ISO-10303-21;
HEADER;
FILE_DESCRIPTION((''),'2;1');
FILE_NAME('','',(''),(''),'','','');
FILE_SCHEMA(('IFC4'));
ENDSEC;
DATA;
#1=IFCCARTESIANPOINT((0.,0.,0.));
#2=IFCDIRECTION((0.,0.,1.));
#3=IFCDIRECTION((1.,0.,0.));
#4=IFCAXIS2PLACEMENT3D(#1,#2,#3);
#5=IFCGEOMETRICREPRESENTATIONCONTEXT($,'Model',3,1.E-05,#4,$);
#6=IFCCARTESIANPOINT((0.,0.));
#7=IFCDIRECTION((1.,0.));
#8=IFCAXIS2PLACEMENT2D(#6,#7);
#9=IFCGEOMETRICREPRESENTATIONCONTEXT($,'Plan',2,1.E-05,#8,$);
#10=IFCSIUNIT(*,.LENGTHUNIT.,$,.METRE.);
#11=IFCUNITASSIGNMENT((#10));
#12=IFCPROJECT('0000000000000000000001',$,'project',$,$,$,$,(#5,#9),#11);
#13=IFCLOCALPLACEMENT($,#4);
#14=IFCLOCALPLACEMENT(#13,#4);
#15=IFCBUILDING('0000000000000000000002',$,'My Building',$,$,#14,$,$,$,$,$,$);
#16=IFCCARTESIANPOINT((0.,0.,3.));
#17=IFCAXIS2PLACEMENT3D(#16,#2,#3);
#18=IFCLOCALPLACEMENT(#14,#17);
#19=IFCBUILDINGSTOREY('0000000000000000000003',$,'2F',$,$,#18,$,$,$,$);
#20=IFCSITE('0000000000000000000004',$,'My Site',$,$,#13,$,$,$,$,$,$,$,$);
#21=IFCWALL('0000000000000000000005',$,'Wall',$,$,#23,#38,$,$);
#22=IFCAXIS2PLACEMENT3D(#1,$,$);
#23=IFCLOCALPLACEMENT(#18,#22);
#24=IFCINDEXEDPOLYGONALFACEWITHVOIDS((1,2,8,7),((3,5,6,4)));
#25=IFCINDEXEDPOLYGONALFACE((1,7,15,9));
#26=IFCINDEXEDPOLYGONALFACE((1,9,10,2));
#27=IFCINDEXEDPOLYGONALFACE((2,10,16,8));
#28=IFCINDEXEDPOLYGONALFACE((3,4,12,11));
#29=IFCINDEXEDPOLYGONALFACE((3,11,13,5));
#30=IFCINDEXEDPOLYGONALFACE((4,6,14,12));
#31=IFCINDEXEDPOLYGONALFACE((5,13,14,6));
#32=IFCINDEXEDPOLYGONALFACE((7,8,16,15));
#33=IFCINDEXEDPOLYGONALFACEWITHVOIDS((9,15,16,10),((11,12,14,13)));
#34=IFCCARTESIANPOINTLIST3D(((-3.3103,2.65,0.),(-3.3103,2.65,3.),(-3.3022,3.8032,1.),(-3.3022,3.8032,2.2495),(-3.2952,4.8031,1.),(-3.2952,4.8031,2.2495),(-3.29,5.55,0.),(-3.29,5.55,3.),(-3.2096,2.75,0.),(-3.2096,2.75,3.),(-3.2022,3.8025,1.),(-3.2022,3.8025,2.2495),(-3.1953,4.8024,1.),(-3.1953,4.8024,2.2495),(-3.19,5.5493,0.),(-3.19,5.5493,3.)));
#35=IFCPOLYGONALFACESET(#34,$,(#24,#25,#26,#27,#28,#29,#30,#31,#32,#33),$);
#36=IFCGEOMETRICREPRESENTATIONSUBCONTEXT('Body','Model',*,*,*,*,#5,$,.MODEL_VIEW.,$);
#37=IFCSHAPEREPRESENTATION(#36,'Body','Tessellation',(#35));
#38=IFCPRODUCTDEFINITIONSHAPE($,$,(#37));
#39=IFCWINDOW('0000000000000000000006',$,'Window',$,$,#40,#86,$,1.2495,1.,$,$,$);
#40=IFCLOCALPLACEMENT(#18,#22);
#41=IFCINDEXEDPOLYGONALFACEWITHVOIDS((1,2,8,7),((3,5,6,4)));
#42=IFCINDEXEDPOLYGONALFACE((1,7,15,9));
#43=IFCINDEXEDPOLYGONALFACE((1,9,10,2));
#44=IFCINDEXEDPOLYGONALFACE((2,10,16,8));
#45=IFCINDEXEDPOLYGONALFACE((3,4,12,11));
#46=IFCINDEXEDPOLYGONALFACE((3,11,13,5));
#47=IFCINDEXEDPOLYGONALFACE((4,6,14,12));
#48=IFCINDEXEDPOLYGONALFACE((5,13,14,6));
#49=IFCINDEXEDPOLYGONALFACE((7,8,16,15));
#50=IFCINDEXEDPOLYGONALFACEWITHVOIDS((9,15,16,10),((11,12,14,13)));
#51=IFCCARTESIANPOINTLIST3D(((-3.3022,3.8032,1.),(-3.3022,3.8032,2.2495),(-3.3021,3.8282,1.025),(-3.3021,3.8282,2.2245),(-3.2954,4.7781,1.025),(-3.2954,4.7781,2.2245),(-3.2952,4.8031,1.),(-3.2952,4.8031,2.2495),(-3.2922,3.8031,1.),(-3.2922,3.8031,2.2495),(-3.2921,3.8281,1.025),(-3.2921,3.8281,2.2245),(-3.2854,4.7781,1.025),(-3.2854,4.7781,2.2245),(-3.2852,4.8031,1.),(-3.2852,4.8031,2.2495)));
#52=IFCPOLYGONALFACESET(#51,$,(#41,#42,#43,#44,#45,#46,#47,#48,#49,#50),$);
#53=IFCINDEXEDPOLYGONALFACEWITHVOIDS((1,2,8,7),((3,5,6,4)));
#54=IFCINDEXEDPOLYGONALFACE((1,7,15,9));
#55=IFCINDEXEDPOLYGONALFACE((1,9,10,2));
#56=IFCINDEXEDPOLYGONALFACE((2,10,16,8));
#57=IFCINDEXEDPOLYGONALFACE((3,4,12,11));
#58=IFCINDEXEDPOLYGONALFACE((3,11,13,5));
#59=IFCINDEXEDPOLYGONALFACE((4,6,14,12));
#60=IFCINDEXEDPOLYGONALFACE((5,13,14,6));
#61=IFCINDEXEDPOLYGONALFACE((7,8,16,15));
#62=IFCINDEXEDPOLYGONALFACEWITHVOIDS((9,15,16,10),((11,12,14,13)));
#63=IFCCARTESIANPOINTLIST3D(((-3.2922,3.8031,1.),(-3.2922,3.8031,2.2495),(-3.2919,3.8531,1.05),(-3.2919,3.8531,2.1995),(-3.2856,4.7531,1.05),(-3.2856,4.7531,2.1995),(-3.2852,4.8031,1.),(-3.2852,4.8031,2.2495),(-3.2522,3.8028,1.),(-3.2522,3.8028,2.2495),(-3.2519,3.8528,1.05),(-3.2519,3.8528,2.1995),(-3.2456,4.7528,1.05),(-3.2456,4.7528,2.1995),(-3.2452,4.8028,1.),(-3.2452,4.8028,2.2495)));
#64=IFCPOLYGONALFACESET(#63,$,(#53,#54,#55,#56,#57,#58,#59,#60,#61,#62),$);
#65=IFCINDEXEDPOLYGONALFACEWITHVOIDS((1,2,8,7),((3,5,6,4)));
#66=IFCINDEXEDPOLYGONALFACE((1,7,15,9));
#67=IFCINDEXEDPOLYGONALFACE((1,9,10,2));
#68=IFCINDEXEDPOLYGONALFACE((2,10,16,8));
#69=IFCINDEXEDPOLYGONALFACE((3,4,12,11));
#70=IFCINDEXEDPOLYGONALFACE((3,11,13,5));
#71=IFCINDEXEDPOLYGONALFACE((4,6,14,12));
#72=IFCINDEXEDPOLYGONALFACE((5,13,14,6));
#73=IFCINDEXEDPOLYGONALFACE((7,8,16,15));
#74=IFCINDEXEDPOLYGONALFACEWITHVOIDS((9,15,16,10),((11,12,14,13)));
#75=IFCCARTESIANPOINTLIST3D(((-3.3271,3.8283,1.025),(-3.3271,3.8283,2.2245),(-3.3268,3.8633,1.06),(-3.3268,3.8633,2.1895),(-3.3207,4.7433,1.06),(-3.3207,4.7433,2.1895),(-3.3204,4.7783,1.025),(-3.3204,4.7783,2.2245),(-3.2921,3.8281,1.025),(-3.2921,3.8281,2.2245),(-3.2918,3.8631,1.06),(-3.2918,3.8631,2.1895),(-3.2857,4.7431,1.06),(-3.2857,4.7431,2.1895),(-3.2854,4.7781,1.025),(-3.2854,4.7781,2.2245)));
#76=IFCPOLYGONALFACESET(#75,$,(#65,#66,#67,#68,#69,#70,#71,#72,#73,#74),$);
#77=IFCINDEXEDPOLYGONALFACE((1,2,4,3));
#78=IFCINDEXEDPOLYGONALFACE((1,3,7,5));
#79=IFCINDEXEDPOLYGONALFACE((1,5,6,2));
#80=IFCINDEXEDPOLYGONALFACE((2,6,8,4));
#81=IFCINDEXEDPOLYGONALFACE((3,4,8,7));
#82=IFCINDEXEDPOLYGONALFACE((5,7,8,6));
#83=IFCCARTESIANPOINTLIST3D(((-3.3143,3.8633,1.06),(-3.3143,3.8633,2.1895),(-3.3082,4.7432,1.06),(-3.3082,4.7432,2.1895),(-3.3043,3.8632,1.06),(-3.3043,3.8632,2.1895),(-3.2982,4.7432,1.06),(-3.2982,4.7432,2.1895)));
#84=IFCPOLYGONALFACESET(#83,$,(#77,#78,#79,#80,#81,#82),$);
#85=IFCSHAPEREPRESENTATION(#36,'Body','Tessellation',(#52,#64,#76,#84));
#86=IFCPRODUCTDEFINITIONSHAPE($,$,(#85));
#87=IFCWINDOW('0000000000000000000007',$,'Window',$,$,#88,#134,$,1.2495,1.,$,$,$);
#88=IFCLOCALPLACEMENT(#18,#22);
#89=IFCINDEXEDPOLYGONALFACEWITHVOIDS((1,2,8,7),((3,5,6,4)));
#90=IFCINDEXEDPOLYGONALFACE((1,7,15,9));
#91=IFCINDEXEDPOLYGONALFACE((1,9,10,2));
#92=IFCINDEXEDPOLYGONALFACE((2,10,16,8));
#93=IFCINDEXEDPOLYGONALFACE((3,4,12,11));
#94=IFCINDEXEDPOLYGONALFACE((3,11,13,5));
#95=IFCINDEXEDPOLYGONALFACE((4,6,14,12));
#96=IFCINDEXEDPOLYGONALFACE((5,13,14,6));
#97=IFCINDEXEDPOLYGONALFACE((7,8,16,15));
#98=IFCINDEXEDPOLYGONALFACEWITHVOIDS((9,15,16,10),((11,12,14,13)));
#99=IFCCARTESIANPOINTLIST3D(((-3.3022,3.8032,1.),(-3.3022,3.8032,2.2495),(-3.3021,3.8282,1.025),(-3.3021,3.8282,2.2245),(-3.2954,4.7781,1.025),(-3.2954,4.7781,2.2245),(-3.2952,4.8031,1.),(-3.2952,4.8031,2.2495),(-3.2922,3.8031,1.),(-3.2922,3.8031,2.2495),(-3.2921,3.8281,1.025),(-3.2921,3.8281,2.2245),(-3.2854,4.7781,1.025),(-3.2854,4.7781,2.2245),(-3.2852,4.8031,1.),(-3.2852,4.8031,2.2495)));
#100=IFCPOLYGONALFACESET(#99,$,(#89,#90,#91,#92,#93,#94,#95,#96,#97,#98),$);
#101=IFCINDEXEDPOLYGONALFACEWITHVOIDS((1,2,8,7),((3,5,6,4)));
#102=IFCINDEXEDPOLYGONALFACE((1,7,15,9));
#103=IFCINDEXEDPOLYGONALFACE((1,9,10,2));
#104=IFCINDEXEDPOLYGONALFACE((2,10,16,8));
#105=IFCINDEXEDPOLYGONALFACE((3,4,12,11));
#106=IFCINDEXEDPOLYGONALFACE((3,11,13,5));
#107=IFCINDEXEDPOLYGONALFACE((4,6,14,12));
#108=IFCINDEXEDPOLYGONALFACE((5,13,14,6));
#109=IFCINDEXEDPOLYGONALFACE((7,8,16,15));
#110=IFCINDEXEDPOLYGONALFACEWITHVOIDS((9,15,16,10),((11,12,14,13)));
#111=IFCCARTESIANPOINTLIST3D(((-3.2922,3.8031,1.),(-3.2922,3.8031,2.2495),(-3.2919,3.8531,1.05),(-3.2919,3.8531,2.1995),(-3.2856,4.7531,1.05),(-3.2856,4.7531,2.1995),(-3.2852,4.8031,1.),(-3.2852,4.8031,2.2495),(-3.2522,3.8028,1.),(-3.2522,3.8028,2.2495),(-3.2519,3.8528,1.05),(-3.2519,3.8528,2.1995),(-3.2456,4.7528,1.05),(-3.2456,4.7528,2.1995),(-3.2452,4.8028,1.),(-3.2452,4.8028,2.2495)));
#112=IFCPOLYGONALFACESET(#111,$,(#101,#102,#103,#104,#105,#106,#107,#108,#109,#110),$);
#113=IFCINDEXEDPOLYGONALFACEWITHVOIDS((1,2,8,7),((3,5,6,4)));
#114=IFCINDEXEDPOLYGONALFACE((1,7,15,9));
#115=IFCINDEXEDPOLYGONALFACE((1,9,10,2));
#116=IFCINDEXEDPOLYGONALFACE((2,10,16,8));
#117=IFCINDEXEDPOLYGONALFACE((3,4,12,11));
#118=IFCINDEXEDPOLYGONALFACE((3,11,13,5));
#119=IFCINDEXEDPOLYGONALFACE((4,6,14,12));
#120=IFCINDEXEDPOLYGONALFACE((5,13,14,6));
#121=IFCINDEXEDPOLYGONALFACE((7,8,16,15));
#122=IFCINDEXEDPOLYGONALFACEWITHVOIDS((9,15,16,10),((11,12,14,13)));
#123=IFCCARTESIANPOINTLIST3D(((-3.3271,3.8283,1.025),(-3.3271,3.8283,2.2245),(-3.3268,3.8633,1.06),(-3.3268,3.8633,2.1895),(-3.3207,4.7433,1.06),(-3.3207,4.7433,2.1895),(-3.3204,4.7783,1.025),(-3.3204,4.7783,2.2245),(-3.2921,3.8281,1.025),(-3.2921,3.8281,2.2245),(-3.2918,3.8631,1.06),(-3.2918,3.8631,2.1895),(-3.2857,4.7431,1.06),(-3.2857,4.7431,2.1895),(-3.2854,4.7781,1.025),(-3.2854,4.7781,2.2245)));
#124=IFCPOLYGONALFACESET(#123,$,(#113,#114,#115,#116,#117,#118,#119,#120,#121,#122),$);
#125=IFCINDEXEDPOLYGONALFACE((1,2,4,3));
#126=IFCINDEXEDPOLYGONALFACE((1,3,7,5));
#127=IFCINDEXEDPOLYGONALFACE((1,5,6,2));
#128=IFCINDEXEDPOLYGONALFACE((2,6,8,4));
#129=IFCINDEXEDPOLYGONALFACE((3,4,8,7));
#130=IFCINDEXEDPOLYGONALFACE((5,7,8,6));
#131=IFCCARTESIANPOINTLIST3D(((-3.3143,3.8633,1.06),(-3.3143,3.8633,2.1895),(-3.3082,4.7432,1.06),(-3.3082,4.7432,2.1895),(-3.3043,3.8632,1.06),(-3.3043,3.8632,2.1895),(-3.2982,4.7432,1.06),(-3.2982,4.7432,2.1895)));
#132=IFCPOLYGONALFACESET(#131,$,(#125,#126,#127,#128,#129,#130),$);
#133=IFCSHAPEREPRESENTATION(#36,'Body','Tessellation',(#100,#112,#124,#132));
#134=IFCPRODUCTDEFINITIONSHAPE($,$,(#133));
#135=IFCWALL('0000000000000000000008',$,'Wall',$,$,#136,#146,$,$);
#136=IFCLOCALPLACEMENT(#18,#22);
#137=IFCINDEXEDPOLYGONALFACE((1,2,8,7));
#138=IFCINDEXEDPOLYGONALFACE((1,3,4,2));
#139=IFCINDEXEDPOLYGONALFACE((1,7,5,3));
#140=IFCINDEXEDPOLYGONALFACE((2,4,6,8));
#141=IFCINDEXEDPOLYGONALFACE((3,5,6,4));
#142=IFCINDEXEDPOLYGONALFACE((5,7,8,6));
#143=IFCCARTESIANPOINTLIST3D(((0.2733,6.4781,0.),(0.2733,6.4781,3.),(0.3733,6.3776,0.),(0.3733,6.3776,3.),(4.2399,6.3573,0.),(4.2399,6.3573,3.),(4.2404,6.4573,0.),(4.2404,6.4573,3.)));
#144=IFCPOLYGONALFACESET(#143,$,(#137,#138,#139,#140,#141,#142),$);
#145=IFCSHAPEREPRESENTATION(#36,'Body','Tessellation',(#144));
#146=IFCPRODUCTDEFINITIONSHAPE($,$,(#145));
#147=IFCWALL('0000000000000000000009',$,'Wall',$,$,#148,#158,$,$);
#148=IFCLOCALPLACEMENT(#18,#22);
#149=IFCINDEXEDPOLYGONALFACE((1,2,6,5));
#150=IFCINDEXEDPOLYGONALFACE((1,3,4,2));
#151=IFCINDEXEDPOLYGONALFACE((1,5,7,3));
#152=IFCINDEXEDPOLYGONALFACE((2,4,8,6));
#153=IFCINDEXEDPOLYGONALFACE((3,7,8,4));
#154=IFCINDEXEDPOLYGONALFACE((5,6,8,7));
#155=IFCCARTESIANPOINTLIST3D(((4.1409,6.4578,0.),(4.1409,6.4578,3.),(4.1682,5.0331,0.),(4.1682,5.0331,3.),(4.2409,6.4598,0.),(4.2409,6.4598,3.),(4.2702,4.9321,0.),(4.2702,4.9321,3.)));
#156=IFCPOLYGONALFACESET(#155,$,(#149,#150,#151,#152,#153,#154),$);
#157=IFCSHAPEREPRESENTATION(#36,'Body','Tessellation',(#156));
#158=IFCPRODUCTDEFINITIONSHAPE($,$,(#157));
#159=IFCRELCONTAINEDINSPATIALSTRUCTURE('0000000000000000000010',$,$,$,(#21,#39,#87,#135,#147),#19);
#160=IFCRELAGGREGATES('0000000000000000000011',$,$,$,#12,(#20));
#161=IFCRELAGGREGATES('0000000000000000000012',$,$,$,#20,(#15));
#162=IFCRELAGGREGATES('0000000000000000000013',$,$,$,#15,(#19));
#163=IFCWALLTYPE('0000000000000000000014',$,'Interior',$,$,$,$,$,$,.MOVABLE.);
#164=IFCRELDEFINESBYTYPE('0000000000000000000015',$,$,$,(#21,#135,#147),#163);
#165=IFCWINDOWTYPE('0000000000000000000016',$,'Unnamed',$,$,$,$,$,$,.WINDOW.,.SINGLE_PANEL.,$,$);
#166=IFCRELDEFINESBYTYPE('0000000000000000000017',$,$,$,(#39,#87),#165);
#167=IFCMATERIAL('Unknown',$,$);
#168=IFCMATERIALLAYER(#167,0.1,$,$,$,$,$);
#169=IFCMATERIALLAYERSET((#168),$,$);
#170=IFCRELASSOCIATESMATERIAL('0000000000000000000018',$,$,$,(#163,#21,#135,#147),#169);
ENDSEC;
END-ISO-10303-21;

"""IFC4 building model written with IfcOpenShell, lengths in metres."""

from ifc_helpers import new_model, entity, si_unit, frame, origin_with_axes, origin_2d_with_axis, place, context, subcontext, project, spatial, line, indexed_curve, outline, extrude, shape, source, transform, mapped, material, layer, layer_set, layer_usage, type_object, type_shapes, element, fill, save


model = new_model("IFC4")

# Units and contexts
model_context = context("Model", 3, precision=1e-05, world=origin_with_axes())
plan_context = context("Plan", 2, precision=1e-05, world=origin_2d_with_axis())
body_context_1 = subcontext(model_context, "Body", "Model", "MODEL_VIEW")
body_context_2 = subcontext(plan_context, "Body", "Plan", "PLAN_VIEW")
ifc_project = project(units=[si_unit("LENGTHUNIT", "METRE")], contexts=[model_context, plan_context])

# Site, building, storey
site_placement = place(None, origin_with_axes())
site = spatial("IfcSite", under=ifc_project, at=site_placement, Name="My Site")
building_placement = place(site_placement, origin_with_axes())
building = spatial("IfcBuilding", under=site, at=building_placement, Name="My Building")
storey_placement = place(building_placement, frame((0.0, 0.0, 3.0), z_axis=(0.0, 0.0, 1.0), x_axis=(1.0, 0.0, 0.0)))
storey = spatial("IfcBuildingStorey", under=building, at=storey_placement, Name="2F")

# Shared definitions
ifc_material = material(Name="Unknown")

# Shared definitions
ifc_layer_1 = layer(ifc_material, 0.1)
ifc_layer_set_1 = layer_set([ifc_layer_1])
wall_type = type_object("IfcWallType", Name="Interior", PredefinedType="MOVABLE", material=ifc_layer_set_1)

# Shared definitions
shared_shape_1 = source(origin_with_axes(), body_context_1, "Body", "SweptSolid", [
    extrude(outline(indexed_curve([(0.0, 0.0), (1.0, 0.0), (1.0, 1.2495), (0.0, 1.2495)], segments=[line(1, 2, 3, 4, 1)])), frame((0.0, -0.6, 0.0), z_axis=(0.0, -1.0, 0.0), x_axis=(1.0, 0.0, 0.0)), (0.0, 0.0, -1.0), 1.2),
])
window_type = type_object("IfcWindowType", Name="Unnamed", PartitioningType="SINGLE_PANEL", PredefinedType="WINDOW")
shared_shape_2 = source(origin_with_axes(), body_context_1, "Body", "SweptSolid", [
    extrude(outline(indexed_curve([(0.0, 0.0), (1.0, 0.0), (1.0, 1.2495), (0.0, 1.2495)], segments=[line(1, 2, 3, 4, 1)]), holes=[indexed_curve([(0.025, 0.025), (0.975, 0.025), (0.975, 1.2245), (0.025, 1.2245)], segments=[line(1, 2, 3, 4, 1)])]), frame((0.0, 0.09, 0.0), z_axis=(0.0, -1.0, 0.0), x_axis=(1.0, 0.0, 0.0)), (0.0, 0.0, -1.0), 0.01),
    extrude(outline(indexed_curve([(0.0, 0.0), (1.0, 0.0), (1.0, 1.2495), (0.0, 1.2495)], segments=[line(1, 2, 3, 4, 1)]), holes=[indexed_curve([(0.05, 0.05), (0.95, 0.05), (0.95, 1.1995), (0.05, 1.1995)], segments=[line(1, 2, 3, 4, 1)])]), frame((0.0, 0.05, 0.0), z_axis=(0.0, -1.0, 0.0), x_axis=(1.0, 0.0, 0.0)), (0.0, 0.0, -1.0), 0.04),
    extrude(outline(indexed_curve([(0.0, 0.0), (0.95, 0.0), (0.95, 1.1995), (0.0, 1.1995)], segments=[line(1, 2, 3, 4, 1)]), holes=[indexed_curve([(0.035, 0.035), (0.915, 0.035), (0.915, 1.1645), (0.035, 1.1645)], segments=[line(1, 2, 3, 4, 1)])]), frame((0.025, 0.09, 0.025), z_axis=(0.0, -1.0, 0.0), x_axis=(1.0, 0.0, 0.0)), (0.0, 0.0, -1.0), 0.035),
    extrude(outline(indexed_curve([(0.035, 0.035), (0.915, 0.035), (0.915, 1.1645), (0.035, 1.1645)], segments=[line(1, 2, 3, 4, 1)])), frame((0.025, 0.1025, 0.025), z_axis=(0.0, -1.0, 0.0), x_axis=(1.0, 0.0, 0.0)), (0.0, 0.0, -1.0), 0.01),
])
shared_shape_3 = source(origin_with_axes(), body_context_2, "Body", "Curve2D", [
    entity("IfcIndexedPolyCurve", entity("IfcCartesianPointList2D", [[0.05, 0.05], [0.95, 0.05]])),
    entity("IfcIndexedPolyCurve", entity("IfcCartesianPointList2D", [[0.0, 0.1], [0.025, 0.1], [0.025, 0.09], [0.05, 0.09], [0.05, 0.05], [0.0, 0.05]]), [entity("IfcLineIndex", [1, 2, 3, 4, 5, 6, 1])]),
    entity("IfcIndexedPolyCurve", entity("IfcCartesianPointList2D", [[1.0, 0.1], [0.975, 0.1], [0.975, 0.09], [0.95, 0.09], [0.95, 0.05], [1.0, 0.05]]), [entity("IfcLineIndex", [1, 2, 3, 4, 5, 6, 1])]),
    entity("IfcIndexedPolyCurve", entity("IfcCartesianPointList2D", [[0.025, 0.09], [0.06, 0.09], [0.06, 0.125], [0.025, 0.125]]), [entity("IfcLineIndex", [1, 2, 3, 4, 1])]),
    entity("IfcIndexedPolyCurve", entity("IfcCartesianPointList2D", [[0.975, 0.09], [0.94, 0.09], [0.94, 0.125], [0.975, 0.125]]), [entity("IfcLineIndex", [1, 2, 3, 4, 1])]),
    entity("IfcIndexedPolyCurve", entity("IfcCartesianPointList2D", [[0.06, 0.09], [0.94, 0.09]])),
    entity("IfcIndexedPolyCurve", entity("IfcCartesianPointList2D", [[0.06, 0.125], [0.94, 0.125]])),
    entity("IfcIndexedPolyCurve", entity("IfcCartesianPointList2D", [[0.06, 0.1075], [0.94, 0.1075]])),
])
type_shapes(window_type, [shared_shape_2, shared_shape_3])

# Wall, openings, windows
ifc_layer_usage_1 = layer_usage(ifc_layer_set_1, "AXIS2", "POSITIVE", 0.0)
wall_1_placement = place(storey_placement, frame((-3.29, 5.55, 0.0), z_axis=(0.0, 0.0, 1.0), x_axis=(-0.006981, -0.999976, 0.0)))
wall_1 = element("IfcWall", 1, at=wall_1_placement, inside=storey, type_object=wall_type, material=ifc_layer_usage_1, Name="Wall", context=body_context_1, shape_type="SweptSolid", body=[
    extrude(outline(indexed_curve([(0.0, 0.0), (0.0, 0.1), (2.7993, 0.1), (2.9, 0.0)], segments=[line(1, 2, 3, 4, 1)])), origin_with_axes(), (0.0, 0.0, 1.0), 3.0),
])
opening_1_placement = place(wall_1_placement, frame((1.7468, 0.1, 1.0), z_axis=(0.0, 0.0, 1.0), x_axis=(-1.0, 0.0, 0.0)))
opening_1 = element("IfcOpeningElement", 2, at=opening_1_placement, cuts=wall_1, PredefinedType="OPENING", context=body_context_1, shape_type="MappedRepresentation", body=[
    mapped(shared_shape_1, transform((0.0, 0.0, 0.0), x_axis=(1.0, 0.0, 0.0), y_axis=(0.0, 1.0, 0.0), z_axis=(0.0, 0.0, 1.0), scale=1.0)),
])
opening_2_placement = place(wall_1_placement, frame((1.7468, 0.1, 1.0), z_axis=(0.0, 0.0, 1.0), x_axis=(-1.0, 0.0, 0.0)))
opening_2 = element("IfcOpeningElement", 3, at=opening_2_placement, cuts=wall_1, PredefinedType="OPENING", context=body_context_1, shape_type="MappedRepresentation", body=[
    mapped(shared_shape_1, transform((0.0, 0.0, 0.0), x_axis=(1.0, 0.0, 0.0), y_axis=(0.0, 1.0, 0.0), z_axis=(0.0, 0.0, 1.0), scale=1.0)),
])
window_1_placement = place(opening_1_placement, frame((0.0, 0.0, 0.0), z_axis=(0.0, 0.0, 1.0), x_axis=(1.0, 0.0, 0.0)))
window_1 = element("IfcWindow", 4, at=window_1_placement, inside=storey, type_object=window_type, Name="Window", OverallHeight=1.2495, OverallWidth=1.0, shapes=[
    shape(body_context_1, "Body", "MappedRepresentation", [mapped(shared_shape_2, transform((0.0, 0.0, 0.0), x_axis=(1.0, 0.0, 0.0), y_axis=(0.0, 1.0, 0.0), z_axis=(0.0, 0.0, 1.0), scale=1.0))]),
    shape(body_context_2, "Body", "MappedRepresentation", [mapped(shared_shape_3, transform((0.0, 0.0, 0.0), x_axis=(1.0, 0.0, 0.0), y_axis=(0.0, 1.0, 0.0), z_axis=(0.0, 0.0, 1.0), scale=1.0))]),
])
fill(opening_1, window_1)
window_2_placement = place(opening_2_placement, frame((0.0, 0.0, 0.0), z_axis=(0.0, 0.0, 1.0), x_axis=(1.0, 0.0, 0.0)))
window_2 = element("IfcWindow", 5, at=window_2_placement, inside=storey, type_object=window_type, Name="Window", OverallHeight=1.2495, OverallWidth=1.0, shapes=[
    shape(body_context_1, "Body", "MappedRepresentation", [mapped(shared_shape_2, transform((0.0, 0.0, 0.0), x_axis=(1.0, 0.0, 0.0), y_axis=(0.0, 1.0, 0.0), z_axis=(0.0, 0.0, 1.0), scale=1.0))]),
    shape(body_context_2, "Body", "MappedRepresentation", [mapped(shared_shape_3, transform((0.0, 0.0, 0.0), x_axis=(1.0, 0.0, 0.0), y_axis=(0.0, 1.0, 0.0), z_axis=(0.0, 0.0, 1.0), scale=1.0))]),
])
fill(opening_2, window_2)

# Walls
ifc_layer_usage_2 = layer_usage(ifc_layer_set_1, "AXIS2", "POSITIVE", 0.0)
wall_2_placement = place(storey_placement, frame((0.3733, 6.3776, 0.0), z_axis=(0.0, 0.0, 1.0), x_axis=(0.999986, -0.005236, 0.0)))
element("IfcWall", 6, at=wall_2_placement, inside=storey, type_object=wall_type, material=ifc_layer_usage_2, Name="Wall", context=body_context_1, shape_type="SweptSolid", body=[
    extrude(outline(indexed_curve([(0.0, 0.0), (-0.1005, 0.1), (3.8666, 0.1), (3.8666, 0.0)], segments=[line(1, 2, 3, 4, 1)])), origin_with_axes(), (0.0, 0.0, 1.0), 3.0),
])
ifc_layer_usage_3 = layer_usage(ifc_layer_set_1, "AXIS2", "POSITIVE", 0.0)
wall_3_placement = place(storey_placement, frame((4.1409, 6.4578, 0.0), z_axis=(0.0, 0.0, 1.0), x_axis=(0.019197, -0.999816, 0.0)))
element("IfcWall", 7, at=wall_3_placement, inside=storey, type_object=wall_type, material=ifc_layer_usage_3, Name="Wall", context=body_context_1, shape_type="SweptSolid", body=[
    extrude(outline(indexed_curve([(0.0, 0.0), (0.0, 0.1), (1.5279, 0.1), (1.425, 0.0)], segments=[line(1, 2, 3, 4, 1)])), origin_with_axes(), (0.0, 0.0, 1.0), 3.0),
])

save(model, "model.ifc")
